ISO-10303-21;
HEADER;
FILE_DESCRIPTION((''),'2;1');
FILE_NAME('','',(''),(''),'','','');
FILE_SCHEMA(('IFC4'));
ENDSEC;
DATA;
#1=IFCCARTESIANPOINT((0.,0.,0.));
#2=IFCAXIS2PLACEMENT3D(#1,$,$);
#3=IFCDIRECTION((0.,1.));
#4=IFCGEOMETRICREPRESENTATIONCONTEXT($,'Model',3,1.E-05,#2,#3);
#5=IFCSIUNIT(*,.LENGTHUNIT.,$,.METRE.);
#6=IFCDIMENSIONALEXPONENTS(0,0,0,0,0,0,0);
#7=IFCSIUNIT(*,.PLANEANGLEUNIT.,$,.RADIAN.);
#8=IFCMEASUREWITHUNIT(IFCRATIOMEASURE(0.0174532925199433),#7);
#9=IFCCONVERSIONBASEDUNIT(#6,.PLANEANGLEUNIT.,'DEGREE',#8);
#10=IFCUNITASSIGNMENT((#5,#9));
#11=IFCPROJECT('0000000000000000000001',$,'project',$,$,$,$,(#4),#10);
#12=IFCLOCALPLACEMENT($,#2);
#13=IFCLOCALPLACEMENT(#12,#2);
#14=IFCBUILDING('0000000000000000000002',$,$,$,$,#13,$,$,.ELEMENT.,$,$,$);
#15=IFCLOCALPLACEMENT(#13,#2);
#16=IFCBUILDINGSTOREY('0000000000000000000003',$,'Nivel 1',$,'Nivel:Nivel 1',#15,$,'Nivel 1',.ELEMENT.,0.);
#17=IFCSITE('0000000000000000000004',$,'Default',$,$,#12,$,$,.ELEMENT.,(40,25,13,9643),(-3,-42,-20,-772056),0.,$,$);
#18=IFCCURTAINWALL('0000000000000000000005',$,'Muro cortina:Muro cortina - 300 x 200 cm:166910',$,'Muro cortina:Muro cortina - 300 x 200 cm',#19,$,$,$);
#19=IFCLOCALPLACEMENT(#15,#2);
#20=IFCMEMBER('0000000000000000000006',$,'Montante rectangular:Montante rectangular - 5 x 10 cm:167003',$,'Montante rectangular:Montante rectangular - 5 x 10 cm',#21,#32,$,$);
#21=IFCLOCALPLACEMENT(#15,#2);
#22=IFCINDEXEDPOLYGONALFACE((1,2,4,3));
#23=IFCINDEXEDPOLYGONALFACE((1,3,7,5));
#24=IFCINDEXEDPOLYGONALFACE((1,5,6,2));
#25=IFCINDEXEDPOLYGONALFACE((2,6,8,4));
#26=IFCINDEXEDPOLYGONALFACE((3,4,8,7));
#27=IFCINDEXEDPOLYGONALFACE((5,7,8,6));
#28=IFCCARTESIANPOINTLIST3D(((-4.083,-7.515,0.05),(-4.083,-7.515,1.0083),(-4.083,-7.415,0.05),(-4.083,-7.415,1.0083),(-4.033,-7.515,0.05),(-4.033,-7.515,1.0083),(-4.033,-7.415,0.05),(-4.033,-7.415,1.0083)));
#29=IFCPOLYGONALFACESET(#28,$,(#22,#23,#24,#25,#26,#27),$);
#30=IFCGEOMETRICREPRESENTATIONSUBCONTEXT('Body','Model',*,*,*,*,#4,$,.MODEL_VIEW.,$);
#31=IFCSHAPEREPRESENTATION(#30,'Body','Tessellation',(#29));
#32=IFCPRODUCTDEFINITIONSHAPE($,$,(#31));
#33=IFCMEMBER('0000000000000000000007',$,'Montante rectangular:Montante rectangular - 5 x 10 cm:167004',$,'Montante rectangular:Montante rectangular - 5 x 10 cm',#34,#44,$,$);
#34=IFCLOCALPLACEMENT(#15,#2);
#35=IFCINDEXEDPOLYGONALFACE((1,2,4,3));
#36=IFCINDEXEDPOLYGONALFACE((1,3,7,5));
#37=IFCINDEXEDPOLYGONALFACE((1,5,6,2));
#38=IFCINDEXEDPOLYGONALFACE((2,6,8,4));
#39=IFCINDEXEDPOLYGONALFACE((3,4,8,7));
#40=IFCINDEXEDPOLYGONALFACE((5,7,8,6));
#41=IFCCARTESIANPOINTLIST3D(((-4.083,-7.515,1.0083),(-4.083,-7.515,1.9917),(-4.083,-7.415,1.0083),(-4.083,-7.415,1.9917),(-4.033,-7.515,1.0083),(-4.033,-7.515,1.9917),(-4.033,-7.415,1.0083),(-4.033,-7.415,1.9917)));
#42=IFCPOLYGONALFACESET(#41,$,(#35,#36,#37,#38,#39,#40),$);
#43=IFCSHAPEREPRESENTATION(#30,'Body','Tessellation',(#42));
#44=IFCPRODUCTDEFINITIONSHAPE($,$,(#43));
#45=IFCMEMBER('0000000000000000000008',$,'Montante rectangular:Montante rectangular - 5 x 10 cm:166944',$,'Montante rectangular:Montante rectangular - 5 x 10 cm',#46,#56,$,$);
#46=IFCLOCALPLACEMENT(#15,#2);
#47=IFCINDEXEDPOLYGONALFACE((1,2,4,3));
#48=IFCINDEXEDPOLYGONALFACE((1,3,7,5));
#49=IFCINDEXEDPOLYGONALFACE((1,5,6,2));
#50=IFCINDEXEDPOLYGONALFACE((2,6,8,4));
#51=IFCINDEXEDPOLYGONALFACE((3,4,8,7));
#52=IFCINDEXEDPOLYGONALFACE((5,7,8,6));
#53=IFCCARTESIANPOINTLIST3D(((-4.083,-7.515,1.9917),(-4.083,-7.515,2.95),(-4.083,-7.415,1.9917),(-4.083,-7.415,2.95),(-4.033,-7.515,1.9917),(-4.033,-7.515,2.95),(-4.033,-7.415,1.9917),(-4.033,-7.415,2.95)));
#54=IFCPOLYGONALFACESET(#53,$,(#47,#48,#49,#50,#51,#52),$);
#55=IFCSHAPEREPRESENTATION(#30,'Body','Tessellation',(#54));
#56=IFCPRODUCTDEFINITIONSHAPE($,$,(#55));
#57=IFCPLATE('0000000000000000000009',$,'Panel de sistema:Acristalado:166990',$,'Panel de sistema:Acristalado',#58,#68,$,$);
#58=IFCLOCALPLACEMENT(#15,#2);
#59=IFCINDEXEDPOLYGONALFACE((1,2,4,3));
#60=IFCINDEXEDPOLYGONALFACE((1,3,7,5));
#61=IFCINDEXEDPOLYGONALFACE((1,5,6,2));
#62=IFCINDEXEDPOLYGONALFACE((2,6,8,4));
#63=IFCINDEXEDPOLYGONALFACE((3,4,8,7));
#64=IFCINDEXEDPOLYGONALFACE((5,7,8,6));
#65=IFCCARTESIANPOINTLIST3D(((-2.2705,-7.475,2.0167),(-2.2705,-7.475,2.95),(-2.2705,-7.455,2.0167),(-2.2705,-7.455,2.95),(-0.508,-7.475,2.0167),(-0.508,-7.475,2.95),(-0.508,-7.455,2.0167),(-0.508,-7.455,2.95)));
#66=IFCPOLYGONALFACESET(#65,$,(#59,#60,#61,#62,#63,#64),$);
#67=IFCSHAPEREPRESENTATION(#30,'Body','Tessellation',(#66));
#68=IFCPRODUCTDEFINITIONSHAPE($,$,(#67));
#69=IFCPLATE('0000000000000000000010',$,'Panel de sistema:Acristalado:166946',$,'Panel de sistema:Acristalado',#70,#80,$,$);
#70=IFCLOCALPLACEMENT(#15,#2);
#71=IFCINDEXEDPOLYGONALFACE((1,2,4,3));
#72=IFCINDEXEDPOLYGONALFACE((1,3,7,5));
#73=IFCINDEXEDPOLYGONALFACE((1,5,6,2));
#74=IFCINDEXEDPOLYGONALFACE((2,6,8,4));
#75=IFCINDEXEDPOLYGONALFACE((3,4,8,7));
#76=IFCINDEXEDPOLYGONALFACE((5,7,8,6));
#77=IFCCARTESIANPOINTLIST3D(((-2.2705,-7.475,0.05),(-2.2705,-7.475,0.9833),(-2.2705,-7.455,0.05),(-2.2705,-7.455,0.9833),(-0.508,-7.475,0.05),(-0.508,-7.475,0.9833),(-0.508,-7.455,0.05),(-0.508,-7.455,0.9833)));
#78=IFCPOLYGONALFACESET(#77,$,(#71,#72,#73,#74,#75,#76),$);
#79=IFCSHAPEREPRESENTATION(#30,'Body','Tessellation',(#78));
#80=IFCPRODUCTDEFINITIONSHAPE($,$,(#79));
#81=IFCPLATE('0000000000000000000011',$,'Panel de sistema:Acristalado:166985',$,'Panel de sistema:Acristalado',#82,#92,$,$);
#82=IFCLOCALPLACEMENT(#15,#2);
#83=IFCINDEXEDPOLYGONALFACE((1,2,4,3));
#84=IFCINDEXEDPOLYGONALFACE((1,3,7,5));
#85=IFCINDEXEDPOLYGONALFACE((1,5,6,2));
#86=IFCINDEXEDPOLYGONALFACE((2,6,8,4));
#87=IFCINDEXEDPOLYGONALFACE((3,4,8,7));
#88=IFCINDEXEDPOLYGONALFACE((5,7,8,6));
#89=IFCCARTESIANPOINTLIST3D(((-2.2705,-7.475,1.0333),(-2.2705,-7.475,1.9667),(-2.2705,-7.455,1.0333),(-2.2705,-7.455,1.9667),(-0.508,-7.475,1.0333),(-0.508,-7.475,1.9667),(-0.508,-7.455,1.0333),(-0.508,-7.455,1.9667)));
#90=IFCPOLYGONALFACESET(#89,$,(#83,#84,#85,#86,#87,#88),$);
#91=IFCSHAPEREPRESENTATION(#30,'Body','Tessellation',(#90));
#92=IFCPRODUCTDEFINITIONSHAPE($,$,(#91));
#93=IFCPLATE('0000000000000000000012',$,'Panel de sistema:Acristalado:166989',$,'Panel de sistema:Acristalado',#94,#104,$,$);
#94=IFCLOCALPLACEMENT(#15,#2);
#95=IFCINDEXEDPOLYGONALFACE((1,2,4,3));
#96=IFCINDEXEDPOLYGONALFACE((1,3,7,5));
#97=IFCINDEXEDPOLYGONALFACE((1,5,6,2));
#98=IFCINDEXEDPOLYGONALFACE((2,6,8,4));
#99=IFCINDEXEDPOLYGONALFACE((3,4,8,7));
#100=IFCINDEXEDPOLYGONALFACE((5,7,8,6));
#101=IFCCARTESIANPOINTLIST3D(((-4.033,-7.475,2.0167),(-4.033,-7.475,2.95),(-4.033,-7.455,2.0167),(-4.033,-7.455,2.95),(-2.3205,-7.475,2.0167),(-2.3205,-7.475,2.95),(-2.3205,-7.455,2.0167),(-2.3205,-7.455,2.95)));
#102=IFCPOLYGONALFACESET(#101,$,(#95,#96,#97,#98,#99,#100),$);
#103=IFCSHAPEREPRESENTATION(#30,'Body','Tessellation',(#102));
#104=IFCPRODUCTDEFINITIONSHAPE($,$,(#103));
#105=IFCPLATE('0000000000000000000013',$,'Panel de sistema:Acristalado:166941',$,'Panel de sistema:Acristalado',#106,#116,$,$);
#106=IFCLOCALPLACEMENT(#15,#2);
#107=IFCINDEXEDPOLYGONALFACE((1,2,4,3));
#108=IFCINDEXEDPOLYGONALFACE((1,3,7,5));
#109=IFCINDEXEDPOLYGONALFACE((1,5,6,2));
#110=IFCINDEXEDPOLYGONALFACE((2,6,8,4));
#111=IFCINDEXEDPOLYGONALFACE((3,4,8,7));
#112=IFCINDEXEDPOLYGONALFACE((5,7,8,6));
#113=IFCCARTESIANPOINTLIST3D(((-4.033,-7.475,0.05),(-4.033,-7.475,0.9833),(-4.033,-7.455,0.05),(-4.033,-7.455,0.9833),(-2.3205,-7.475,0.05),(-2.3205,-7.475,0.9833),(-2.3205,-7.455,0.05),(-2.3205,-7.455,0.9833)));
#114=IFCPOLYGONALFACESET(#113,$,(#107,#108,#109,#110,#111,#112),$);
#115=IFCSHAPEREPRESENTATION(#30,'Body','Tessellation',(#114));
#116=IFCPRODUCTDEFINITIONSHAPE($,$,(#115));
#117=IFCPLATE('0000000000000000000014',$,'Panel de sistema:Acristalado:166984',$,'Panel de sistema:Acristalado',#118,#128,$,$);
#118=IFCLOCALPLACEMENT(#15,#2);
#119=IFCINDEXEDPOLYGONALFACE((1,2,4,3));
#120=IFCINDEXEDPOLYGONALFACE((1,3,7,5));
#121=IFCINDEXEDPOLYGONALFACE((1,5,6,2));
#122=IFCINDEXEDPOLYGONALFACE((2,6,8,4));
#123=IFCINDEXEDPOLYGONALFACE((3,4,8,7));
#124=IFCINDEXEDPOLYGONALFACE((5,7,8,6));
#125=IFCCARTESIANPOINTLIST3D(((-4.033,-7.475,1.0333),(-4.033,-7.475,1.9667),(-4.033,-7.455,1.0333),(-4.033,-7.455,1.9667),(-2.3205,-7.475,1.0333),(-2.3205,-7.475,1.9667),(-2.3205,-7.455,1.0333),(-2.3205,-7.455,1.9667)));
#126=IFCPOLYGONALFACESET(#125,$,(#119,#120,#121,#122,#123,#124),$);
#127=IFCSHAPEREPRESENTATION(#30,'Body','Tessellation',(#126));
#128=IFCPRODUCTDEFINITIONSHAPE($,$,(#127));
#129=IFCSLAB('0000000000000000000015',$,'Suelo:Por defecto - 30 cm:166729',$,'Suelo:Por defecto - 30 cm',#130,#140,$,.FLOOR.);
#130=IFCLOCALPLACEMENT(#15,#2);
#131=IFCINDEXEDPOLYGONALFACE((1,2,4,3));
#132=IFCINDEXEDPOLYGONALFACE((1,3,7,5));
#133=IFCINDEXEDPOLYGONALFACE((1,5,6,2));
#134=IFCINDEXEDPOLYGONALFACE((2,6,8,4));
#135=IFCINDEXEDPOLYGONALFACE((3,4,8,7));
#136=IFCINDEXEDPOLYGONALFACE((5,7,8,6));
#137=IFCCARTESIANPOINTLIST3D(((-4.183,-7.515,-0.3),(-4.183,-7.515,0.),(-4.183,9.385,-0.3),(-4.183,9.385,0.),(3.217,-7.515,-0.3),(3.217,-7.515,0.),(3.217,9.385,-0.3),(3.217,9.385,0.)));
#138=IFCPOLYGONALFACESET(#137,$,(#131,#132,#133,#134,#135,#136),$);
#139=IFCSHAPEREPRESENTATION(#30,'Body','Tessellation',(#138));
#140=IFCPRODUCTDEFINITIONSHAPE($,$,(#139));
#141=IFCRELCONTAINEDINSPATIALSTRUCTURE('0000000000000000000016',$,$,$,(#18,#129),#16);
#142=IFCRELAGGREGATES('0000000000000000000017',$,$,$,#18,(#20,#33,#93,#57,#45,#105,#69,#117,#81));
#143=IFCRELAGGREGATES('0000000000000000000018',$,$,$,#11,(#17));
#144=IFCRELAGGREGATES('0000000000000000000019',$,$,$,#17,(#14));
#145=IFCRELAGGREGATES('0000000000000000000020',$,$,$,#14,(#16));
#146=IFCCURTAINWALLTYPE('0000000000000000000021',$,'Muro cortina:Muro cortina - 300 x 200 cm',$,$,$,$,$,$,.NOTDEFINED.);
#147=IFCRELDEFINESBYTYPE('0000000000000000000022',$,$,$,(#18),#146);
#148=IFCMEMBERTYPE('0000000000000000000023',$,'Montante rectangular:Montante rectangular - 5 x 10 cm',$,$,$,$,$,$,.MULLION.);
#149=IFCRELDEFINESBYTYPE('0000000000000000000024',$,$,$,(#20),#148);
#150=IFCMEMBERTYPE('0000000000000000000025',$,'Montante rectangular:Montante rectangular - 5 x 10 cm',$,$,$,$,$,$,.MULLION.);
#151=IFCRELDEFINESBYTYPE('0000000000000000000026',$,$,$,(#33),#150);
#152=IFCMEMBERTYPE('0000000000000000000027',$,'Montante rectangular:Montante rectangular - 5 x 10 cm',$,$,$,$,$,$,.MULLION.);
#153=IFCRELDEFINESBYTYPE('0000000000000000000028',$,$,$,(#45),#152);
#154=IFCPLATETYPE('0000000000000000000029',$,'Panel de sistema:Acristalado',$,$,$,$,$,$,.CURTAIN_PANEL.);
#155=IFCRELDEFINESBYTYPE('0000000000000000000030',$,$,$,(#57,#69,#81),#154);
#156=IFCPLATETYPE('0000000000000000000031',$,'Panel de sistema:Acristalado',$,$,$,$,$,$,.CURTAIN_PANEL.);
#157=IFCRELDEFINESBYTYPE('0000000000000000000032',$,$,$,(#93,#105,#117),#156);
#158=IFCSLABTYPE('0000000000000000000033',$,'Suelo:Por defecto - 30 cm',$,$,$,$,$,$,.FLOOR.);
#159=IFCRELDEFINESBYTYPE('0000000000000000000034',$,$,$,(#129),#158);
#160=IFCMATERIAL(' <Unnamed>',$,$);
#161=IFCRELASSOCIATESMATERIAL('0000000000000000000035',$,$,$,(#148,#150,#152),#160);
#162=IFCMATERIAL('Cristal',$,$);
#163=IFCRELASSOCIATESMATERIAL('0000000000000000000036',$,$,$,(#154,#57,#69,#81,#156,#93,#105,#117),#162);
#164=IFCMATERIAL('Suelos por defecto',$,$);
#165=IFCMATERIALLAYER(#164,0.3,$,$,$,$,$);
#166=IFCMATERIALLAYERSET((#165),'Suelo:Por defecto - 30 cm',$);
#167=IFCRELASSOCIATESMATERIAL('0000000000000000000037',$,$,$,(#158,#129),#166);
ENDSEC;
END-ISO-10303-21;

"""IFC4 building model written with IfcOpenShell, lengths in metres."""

from ifc_helpers import new_model, entity, si_unit, converted_unit, direction, frame, origin, origin_2d_with_axis, place, context, subcontext, project, spatial, rectangle, extrude, source, transform, mapped, material, layer, layer_set, layer_usage, type_object, type_shapes, element, aggregate, save


model = new_model("IFC4")

# Units and contexts
model_context = context("Model", 3, precision=1e-05, world=origin(), true_north=direction((0.0, 1.0)))
body_context = subcontext(model_context, "Body", "Model", "MODEL_VIEW")
ifc_project = project(units=[si_unit("LENGTHUNIT", "METRE"), converted_unit("PLANEANGLEUNIT", "DEGREE", entity("IfcRatioMeasure", 0.0174532925199433), si_unit("PLANEANGLEUNIT", "RADIAN"), dimensions=[0, 0, 0, 0, 0, 0, 0])], contexts=[model_context])

# Site, building, storey
site_placement = place(None, origin())
site = spatial("IfcSite", under=ifc_project, at=site_placement, Name="Default", CompositionType="ELEMENT", RefLatitude=(40, 25, 13, 9643), RefLongitude=(-3, -42, -20, -772056), RefElevation=0.0)
building_placement = place(site_placement, origin())
building = spatial("IfcBuilding", under=site, at=building_placement, CompositionType="ELEMENT")
storey_placement = place(building_placement, origin())
storey = spatial("IfcBuildingStorey", under=building, at=storey_placement, Name="Nivel 1", ObjectType="Nivel:Nivel 1", LongName="Nivel 1", CompositionType="ELEMENT", Elevation=0.0)

# Curtain wall, members, plates
curtain_wall_type = type_object("IfcCurtainWallType", Name="Muro cortina:Muro cortina - 300 x 200 cm", PredefinedType="NOTDEFINED")
curtain_wall_placement = place(storey_placement, origin())
curtain_wall = element("IfcCurtainWall", 1, at=curtain_wall_placement, inside=storey, type_object=curtain_wall_type, Name="Muro cortina:Muro cortina - 300 x 200 cm:166910", ObjectType="Muro cortina:Muro cortina - 300 x 200 cm")
ifc_material_1 = material(Name=" <Unnamed>")
member_type_1 = type_object("IfcMemberType", Name="Montante rectangular:Montante rectangular - 5 x 10 cm", PredefinedType="MULLION", material=ifc_material_1)
shared_shape_1 = source(origin(), body_context, "Body", "SweptSolid", [
    extrude(rectangle(XDim=0.1, YDim=0.05, at=origin_2d_with_axis()), frame((-0.025, 0.0, -0.9583), z_axis=(0.0, 0.0, 1.0), x_axis=(0.0, -1.0, 0.0)), (0.0, 0.0, 1.0), 0.9583),
])
type_shapes(member_type_1, [shared_shape_1])
member_1_placement = place(storey_placement, frame((-4.083, -7.465, 1.0083), z_axis=(0.0, 0.0, 1.0), x_axis=(-1.0, 0.0, 0.0)))
member_1 = element("IfcMember", 2, at=member_1_placement, type_object=member_type_1, Name="Montante rectangular:Montante rectangular - 5 x 10 cm:167003", ObjectType="Montante rectangular:Montante rectangular - 5 x 10 cm", context=body_context, shape_type="MappedRepresentation", body=[
    mapped(shared_shape_1, transform((0.0, 0.0, 0.0), scale=1.0)),
])
member_type_2 = type_object("IfcMemberType", Name="Montante rectangular:Montante rectangular - 5 x 10 cm", PredefinedType="MULLION", material=ifc_material_1)
shared_shape_2 = source(origin(), body_context, "Body", "SweptSolid", [
    extrude(rectangle(XDim=0.1, YDim=0.05, at=origin_2d_with_axis()), frame((-0.025, 0.0, -0.9833), z_axis=(0.0, 0.0, 1.0), x_axis=(0.0, -1.0, 0.0)), (0.0, 0.0, 1.0), 0.9833),
])
type_shapes(member_type_2, [shared_shape_2])
member_2_placement = place(storey_placement, frame((-4.083, -7.465, 1.9917), z_axis=(0.0, 0.0, 1.0), x_axis=(-1.0, 0.0, 0.0)))
member_2 = element("IfcMember", 3, at=member_2_placement, type_object=member_type_2, Name="Montante rectangular:Montante rectangular - 5 x 10 cm:167004", ObjectType="Montante rectangular:Montante rectangular - 5 x 10 cm", context=body_context, shape_type="MappedRepresentation", body=[
    mapped(shared_shape_2, transform((0.0, 0.0, 0.0), scale=1.0)),
])
member_type_3 = type_object("IfcMemberType", Name="Montante rectangular:Montante rectangular - 5 x 10 cm", PredefinedType="MULLION", material=ifc_material_1)
shared_shape_3 = source(origin(), body_context, "Body", "SweptSolid", [
    extrude(rectangle(XDim=0.1, YDim=0.05, at=origin_2d_with_axis()), frame((-0.025, 0.0, -0.9583), z_axis=(0.0, 0.0, 1.0), x_axis=(0.0, -1.0, 0.0)), (0.0, 0.0, 1.0), 0.9583),
])
type_shapes(member_type_3, [shared_shape_3])
member_3_placement = place(storey_placement, frame((-4.083, -7.465, 2.95), z_axis=(0.0, 0.0, 1.0), x_axis=(-1.0, 0.0, 0.0)))
member_3 = element("IfcMember", 4, at=member_3_placement, type_object=member_type_3, Name="Montante rectangular:Montante rectangular - 5 x 10 cm:166944", ObjectType="Montante rectangular:Montante rectangular - 5 x 10 cm", context=body_context, shape_type="MappedRepresentation", body=[
    mapped(shared_shape_3, transform((0.0, 0.0, 0.0), scale=1.0)),
])
ifc_material_2 = material(Name="Cristal")
plate_type_1 = type_object("IfcPlateType", Name="Panel de sistema:Acristalado", PredefinedType="CURTAIN_PANEL", material=ifc_material_2)
shared_shape_4 = source(origin(), body_context, "Body", "SweptSolid", [
    extrude(rectangle(XDim=0.02, YDim=1.7625, at=origin_2d_with_axis()), frame((0.0, 0.0, 0.0), z_axis=(0.0, 0.0, 1.0), x_axis=(0.0, 1.0, 0.0)), (0.0, 0.0, 1.0), 0.9333),
])
type_shapes(plate_type_1, [shared_shape_4])
plate_1_placement = place(curtain_wall_placement, frame((-1.3893, -7.465, 2.0167)))
plate_1 = element("IfcPlate", 5, at=plate_1_placement, type_object=plate_type_1, material=ifc_material_2, Name="Panel de sistema:Acristalado:166990", ObjectType="Panel de sistema:Acristalado", context=body_context, shape_type="MappedRepresentation", body=[
    mapped(shared_shape_4, transform((0.0, 0.0, 0.0), scale=1.0)),
])
plate_2_placement = place(curtain_wall_placement, frame((-1.3893, -7.465, 0.05)))
plate_2 = element("IfcPlate", 6, at=plate_2_placement, type_object=plate_type_1, material=ifc_material_2, Name="Panel de sistema:Acristalado:166946", ObjectType="Panel de sistema:Acristalado", context=body_context, shape_type="MappedRepresentation", body=[
    mapped(shared_shape_4, transform((0.0, 0.0, 0.0), scale=1.0)),
])
plate_3_placement = place(curtain_wall_placement, frame((-1.3893, -7.465, 1.0333)))
plate_3 = element("IfcPlate", 7, at=plate_3_placement, type_object=plate_type_1, material=ifc_material_2, Name="Panel de sistema:Acristalado:166985", ObjectType="Panel de sistema:Acristalado", context=body_context, shape_type="MappedRepresentation", body=[
    mapped(shared_shape_4, transform((0.0, 0.0, 0.0), scale=1.0)),
])
plate_type_2 = type_object("IfcPlateType", Name="Panel de sistema:Acristalado", PredefinedType="CURTAIN_PANEL", material=ifc_material_2)
shared_shape_5 = source(origin(), body_context, "Body", "SweptSolid", [
    extrude(rectangle(XDim=0.02, YDim=1.7125, at=origin_2d_with_axis()), frame((0.0, 0.0, 0.0), z_axis=(0.0, 0.0, 1.0), x_axis=(0.0, 1.0, 0.0)), (0.0, 0.0, 1.0), 0.9333),
])
type_shapes(plate_type_2, [shared_shape_5])
plate_4_placement = place(curtain_wall_placement, frame((-3.1768, -7.465, 2.0167)))
plate_4 = element("IfcPlate", 8, at=plate_4_placement, type_object=plate_type_2, material=ifc_material_2, Name="Panel de sistema:Acristalado:166989", ObjectType="Panel de sistema:Acristalado", context=body_context, shape_type="MappedRepresentation", body=[
    mapped(shared_shape_5, transform((0.0, 0.0, 0.0), scale=1.0)),
])
plate_5_placement = place(curtain_wall_placement, frame((-3.1768, -7.465, 0.05)))
plate_5 = element("IfcPlate", 9, at=plate_5_placement, type_object=plate_type_2, material=ifc_material_2, Name="Panel de sistema:Acristalado:166941", ObjectType="Panel de sistema:Acristalado", context=body_context, shape_type="MappedRepresentation", body=[
    mapped(shared_shape_5, transform((0.0, 0.0, 0.0), scale=1.0)),
])
plate_6_placement = place(curtain_wall_placement, frame((-3.1768, -7.465, 1.0333)))
plate_6 = element("IfcPlate", 10, at=plate_6_placement, type_object=plate_type_2, material=ifc_material_2, Name="Panel de sistema:Acristalado:166984", ObjectType="Panel de sistema:Acristalado", context=body_context, shape_type="MappedRepresentation", body=[
    mapped(shared_shape_5, transform((0.0, 0.0, 0.0), scale=1.0)),
])
aggregate(curtain_wall, [member_1, member_2, plate_4, plate_1, member_3, plate_5, plate_2, plate_6, plate_3])

# Slab
ifc_material_3 = material(Name="Suelos por defecto")
ifc_layer_1 = layer(ifc_material_3, 0.3)
ifc_layer_set_1 = layer_set([ifc_layer_1], Name="Suelo:Por defecto - 30 cm")
ifc_layer_usage_1 = layer_usage(ifc_layer_set_1, "AXIS3", "POSITIVE", 0.0)
slab_type = type_object("IfcSlabType", Name="Suelo:Por defecto - 30 cm", PredefinedType="FLOOR", material=ifc_layer_set_1)
slab_placement = place(storey_placement, origin())
element("IfcSlab", 11, at=slab_placement, inside=storey, type_object=slab_type, material=ifc_layer_usage_1, Name="Suelo:Por defecto - 30 cm:166729", ObjectType="Suelo:Por defecto - 30 cm", PredefinedType="FLOOR", context=body_context, shape_type="SweptSolid", body=[
    extrude(rectangle(XDim=16.9, YDim=7.4, at=origin_2d_with_axis()), frame((-0.483, 0.935, 0.0), z_axis=(0.0, 0.0, -1.0), x_axis=(0.0, 1.0, 0.0)), (0.0, 0.0, 1.0), 0.3),
])

save(model, "model.ifc")
